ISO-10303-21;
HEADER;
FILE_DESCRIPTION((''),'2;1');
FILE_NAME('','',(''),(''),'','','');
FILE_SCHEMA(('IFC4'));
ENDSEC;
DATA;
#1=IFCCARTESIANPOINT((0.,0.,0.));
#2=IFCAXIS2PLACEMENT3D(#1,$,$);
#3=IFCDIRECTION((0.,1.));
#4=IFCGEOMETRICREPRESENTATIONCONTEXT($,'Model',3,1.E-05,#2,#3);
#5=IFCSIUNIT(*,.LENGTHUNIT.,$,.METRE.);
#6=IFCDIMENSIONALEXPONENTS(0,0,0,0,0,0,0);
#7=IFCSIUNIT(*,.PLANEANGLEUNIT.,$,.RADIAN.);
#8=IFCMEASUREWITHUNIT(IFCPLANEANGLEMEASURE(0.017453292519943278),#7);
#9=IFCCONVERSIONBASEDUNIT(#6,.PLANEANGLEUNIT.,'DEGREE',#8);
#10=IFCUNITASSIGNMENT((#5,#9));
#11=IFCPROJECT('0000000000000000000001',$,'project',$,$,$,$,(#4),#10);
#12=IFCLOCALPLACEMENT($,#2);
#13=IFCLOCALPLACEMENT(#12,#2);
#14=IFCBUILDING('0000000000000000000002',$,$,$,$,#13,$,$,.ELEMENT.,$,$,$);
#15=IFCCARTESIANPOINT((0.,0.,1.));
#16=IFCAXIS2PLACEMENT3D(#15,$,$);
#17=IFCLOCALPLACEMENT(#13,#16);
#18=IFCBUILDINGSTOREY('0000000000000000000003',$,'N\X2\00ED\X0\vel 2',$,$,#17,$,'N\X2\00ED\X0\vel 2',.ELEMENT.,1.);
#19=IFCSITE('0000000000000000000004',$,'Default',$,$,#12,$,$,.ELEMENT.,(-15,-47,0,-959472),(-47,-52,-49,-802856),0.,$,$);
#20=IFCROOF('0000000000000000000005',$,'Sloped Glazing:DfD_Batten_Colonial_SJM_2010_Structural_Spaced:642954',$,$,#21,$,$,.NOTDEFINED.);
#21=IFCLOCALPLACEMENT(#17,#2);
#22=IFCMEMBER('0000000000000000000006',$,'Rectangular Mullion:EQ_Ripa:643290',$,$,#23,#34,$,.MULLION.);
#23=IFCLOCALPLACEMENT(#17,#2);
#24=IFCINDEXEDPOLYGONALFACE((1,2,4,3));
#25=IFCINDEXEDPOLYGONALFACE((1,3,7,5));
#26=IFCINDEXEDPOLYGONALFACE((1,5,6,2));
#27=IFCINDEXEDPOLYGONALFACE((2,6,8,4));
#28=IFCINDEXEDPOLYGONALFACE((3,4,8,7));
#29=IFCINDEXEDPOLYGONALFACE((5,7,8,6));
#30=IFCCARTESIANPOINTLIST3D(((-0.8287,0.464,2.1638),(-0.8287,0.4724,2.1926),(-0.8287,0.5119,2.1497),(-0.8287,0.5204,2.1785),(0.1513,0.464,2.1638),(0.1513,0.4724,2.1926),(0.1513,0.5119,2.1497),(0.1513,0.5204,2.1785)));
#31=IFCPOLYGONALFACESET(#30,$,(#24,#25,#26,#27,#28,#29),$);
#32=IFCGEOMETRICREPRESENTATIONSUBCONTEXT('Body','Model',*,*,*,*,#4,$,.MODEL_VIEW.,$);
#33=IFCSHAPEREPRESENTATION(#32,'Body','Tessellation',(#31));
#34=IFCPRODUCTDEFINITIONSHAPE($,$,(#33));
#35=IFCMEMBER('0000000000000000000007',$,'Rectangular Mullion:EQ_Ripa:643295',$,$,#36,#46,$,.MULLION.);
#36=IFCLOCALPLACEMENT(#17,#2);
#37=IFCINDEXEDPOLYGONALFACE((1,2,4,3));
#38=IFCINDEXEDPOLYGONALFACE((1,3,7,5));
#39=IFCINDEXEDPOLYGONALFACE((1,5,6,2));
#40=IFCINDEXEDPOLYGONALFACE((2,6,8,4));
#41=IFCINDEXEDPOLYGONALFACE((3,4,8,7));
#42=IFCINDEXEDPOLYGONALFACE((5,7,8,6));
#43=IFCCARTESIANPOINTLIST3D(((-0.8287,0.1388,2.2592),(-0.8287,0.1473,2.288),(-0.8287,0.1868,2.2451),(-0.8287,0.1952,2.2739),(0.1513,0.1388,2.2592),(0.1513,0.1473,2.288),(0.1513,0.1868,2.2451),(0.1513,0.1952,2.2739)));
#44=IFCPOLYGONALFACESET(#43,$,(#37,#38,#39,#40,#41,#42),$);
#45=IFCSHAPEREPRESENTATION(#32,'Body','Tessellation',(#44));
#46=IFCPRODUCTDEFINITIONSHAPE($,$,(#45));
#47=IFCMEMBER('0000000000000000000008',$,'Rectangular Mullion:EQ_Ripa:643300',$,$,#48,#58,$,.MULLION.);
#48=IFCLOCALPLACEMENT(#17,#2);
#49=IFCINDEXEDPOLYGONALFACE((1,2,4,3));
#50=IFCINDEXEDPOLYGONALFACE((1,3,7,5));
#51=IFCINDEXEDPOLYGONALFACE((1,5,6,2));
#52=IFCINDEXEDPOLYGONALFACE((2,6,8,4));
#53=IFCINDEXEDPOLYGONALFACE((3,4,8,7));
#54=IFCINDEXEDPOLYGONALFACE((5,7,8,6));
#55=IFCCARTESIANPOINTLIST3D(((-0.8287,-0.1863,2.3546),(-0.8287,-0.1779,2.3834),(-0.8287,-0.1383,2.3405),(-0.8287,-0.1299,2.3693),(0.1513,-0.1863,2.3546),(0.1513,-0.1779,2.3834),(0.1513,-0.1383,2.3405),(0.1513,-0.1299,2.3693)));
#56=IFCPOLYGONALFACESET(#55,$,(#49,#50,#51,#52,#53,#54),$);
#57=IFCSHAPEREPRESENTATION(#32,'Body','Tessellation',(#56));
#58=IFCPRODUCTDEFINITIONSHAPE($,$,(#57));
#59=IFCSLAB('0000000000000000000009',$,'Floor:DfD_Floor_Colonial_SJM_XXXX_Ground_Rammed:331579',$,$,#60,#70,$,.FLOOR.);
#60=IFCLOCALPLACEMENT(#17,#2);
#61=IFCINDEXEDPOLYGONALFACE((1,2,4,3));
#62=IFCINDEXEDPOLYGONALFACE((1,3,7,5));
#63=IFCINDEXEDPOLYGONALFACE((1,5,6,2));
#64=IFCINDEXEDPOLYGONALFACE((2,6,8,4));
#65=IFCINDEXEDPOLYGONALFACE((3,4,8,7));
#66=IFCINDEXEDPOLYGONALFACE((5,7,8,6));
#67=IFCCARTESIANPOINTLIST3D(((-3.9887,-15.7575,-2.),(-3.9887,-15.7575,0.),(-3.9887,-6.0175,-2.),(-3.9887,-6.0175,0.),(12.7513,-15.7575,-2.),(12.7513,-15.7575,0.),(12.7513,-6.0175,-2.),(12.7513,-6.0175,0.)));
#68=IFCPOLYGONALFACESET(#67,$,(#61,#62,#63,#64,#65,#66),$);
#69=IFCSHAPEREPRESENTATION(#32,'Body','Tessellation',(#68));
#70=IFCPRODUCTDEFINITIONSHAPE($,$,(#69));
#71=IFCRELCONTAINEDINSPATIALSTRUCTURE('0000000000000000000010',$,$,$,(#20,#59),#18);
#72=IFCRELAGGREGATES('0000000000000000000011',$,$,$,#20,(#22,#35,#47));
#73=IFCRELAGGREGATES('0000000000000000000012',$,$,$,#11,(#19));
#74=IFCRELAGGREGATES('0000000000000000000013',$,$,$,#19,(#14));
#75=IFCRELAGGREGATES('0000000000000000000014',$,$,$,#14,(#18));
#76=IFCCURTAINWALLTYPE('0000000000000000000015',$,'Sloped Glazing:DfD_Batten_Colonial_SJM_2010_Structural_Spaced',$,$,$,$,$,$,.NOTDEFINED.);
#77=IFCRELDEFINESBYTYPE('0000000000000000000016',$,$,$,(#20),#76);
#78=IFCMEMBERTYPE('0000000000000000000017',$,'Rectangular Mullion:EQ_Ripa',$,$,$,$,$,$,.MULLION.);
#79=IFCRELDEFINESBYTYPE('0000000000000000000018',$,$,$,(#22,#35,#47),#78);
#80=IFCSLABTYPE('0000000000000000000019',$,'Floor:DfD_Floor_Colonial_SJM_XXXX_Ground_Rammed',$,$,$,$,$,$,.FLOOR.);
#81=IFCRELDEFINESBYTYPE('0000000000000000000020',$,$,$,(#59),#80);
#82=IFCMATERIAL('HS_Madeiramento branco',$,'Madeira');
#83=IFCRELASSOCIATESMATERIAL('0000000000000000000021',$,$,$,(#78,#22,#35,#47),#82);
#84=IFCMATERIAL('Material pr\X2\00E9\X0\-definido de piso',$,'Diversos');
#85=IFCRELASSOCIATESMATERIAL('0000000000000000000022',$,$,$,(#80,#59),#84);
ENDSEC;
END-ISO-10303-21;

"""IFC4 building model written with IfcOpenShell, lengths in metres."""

from ifc_helpers import new_model, entity, si_unit, converted_unit, direction, frame, origin, place, context, subcontext, project, spatial, indexed_curve, outline, extrude, source, transform, mapped, material, type_object, type_shapes, element, aggregate, save


model = new_model("IFC4")

# Units and contexts
model_context = context("Model", 3, precision=1e-05, world=origin(), true_north=direction((0.0, 1.0)))
body_context = subcontext(model_context, "Body", "Model", "MODEL_VIEW")
ifc_project = project(units=[si_unit("LENGTHUNIT", "METRE"), converted_unit("PLANEANGLEUNIT", "DEGREE", entity("IfcPlaneAngleMeasure", 0.017453292519943278), si_unit("PLANEANGLEUNIT", "RADIAN"), dimensions=[0, 0, 0, 0, 0, 0, 0])], contexts=[model_context])

# Site, building, storey
site_placement = place(None, origin())
site = spatial("IfcSite", under=ifc_project, at=site_placement, Name="Default", CompositionType="ELEMENT", RefLatitude=(-15, -47, 0, -959472), RefLongitude=(-47, -52, -49, -802856), RefElevation=0.0)
building_placement = place(site_placement, origin())
building = spatial("IfcBuilding", under=site, at=building_placement, CompositionType="ELEMENT")
storey_placement = place(building_placement, frame((0.0, 0.0, 1.0)))
storey = spatial("IfcBuildingStorey", under=building, at=storey_placement, Name="Nível 2", LongName="Nível 2", CompositionType="ELEMENT", Elevation=1.0)

# Roof, members
curtain_wall_type = type_object("IfcCurtainWallType", Name="Sloped Glazing:DfD_Batten_Colonial_SJM_2010_Structural_Spaced", PredefinedType="NOTDEFINED")
roof_placement = place(storey_placement, frame((0.0, 0.0, -1.0)))
roof = element("IfcRoof", 1, at=roof_placement, inside=storey, type_object=curtain_wall_type, Name="Sloped Glazing:DfD_Batten_Colonial_SJM_2010_Structural_Spaced:642954", PredefinedType="NOTDEFINED")
ifc_material_1 = material(Name="HS_Madeiramento branco", Category="Madeira")
member_type_1 = type_object("IfcMemberType", Name="Rectangular Mullion:EQ_Ripa", PredefinedType="MULLION", material=ifc_material_1)
shared_shape_1 = source(origin(), body_context, "Body", "SweptSolid", [
    extrude(outline(indexed_curve([(-0.025, -0.015), (0.025, -0.015), (0.025, 0.015), (-0.025, 0.015), (-0.025, -0.015)], self_intersect=False)), frame((0.0, 0.0, -0.98), z_axis=(0.0, 0.0, 1.0), x_axis=(-1.0, 0.0, 0.0)), (0.0, 0.0, 1.0), 0.98),
])
type_shapes(member_type_1, [shared_shape_1])
member_1_placement = place(roof_placement, frame((0.1513, 0.4922, 3.1712), z_axis=(1.0, 0.0, 0.0), x_axis=(0.0, -0.95956, 0.281504)))
member_1 = element("IfcMember", 2, at=member_1_placement, type_object=member_type_1, material=ifc_material_1, Name="Rectangular Mullion:EQ_Ripa:643290", PredefinedType="MULLION", context=body_context, shape_type="MappedRepresentation", body=[
    mapped(shared_shape_1, transform((0.0, 0.0, 0.0), scale=1.0)),
])
member_2_placement = place(roof_placement, frame((0.1513, 0.167, 3.2665), z_axis=(1.0, 0.0, 0.0), x_axis=(0.0, -0.95956, 0.281504)))
member_2 = element("IfcMember", 3, at=member_2_placement, type_object=member_type_1, material=ifc_material_1, Name="Rectangular Mullion:EQ_Ripa:643295", PredefinedType="MULLION", context=body_context, shape_type="MappedRepresentation", body=[
    mapped(shared_shape_1, transform((0.0, 0.0, 0.0), scale=1.0)),
])
member_3_placement = place(roof_placement, frame((0.1513, -0.1581, 3.3619), z_axis=(1.0, 0.0, 0.0), x_axis=(0.0, -0.95956, 0.281504)))
member_3 = element("IfcMember", 4, at=member_3_placement, type_object=member_type_1, material=ifc_material_1, Name="Rectangular Mullion:EQ_Ripa:643300", PredefinedType="MULLION", context=body_context, shape_type="MappedRepresentation", body=[
    mapped(shared_shape_1, transform((0.0, 0.0, 0.0), scale=1.0)),
])
aggregate(roof, [member_1, member_2, member_3])

# Slab
ifc_material_2 = material(Name="Material pré-definido de piso", Category="Diversos")
slab_type = type_object("IfcSlabType", Name="Floor:DfD_Floor_Colonial_SJM_XXXX_Ground_Rammed", PredefinedType="FLOOR", material=ifc_material_2)
slab_1_placement = place(storey_placement, origin())
element("IfcSlab", 5, at=slab_1_placement, inside=storey, type_object=slab_type, material=ifc_material_2, Name="Floor:DfD_Floor_Colonial_SJM_XXXX_Ground_Rammed:331579", PredefinedType="FLOOR", context=body_context, shape_type="SweptSolid", body=[
    extrude(outline(indexed_curve([(-4.87, -8.37), (4.87, -8.37), (4.87, 8.37), (-4.87, 8.37), (-4.87, -8.37)], self_intersect=False)), frame((4.3813, -10.8875, 0.0), z_axis=(0.0, 0.0, -1.0), x_axis=(0.0, 1.0, 0.0)), (0.0, 0.0, 1.0), 2.0),
])

save(model, "model.ifc")
